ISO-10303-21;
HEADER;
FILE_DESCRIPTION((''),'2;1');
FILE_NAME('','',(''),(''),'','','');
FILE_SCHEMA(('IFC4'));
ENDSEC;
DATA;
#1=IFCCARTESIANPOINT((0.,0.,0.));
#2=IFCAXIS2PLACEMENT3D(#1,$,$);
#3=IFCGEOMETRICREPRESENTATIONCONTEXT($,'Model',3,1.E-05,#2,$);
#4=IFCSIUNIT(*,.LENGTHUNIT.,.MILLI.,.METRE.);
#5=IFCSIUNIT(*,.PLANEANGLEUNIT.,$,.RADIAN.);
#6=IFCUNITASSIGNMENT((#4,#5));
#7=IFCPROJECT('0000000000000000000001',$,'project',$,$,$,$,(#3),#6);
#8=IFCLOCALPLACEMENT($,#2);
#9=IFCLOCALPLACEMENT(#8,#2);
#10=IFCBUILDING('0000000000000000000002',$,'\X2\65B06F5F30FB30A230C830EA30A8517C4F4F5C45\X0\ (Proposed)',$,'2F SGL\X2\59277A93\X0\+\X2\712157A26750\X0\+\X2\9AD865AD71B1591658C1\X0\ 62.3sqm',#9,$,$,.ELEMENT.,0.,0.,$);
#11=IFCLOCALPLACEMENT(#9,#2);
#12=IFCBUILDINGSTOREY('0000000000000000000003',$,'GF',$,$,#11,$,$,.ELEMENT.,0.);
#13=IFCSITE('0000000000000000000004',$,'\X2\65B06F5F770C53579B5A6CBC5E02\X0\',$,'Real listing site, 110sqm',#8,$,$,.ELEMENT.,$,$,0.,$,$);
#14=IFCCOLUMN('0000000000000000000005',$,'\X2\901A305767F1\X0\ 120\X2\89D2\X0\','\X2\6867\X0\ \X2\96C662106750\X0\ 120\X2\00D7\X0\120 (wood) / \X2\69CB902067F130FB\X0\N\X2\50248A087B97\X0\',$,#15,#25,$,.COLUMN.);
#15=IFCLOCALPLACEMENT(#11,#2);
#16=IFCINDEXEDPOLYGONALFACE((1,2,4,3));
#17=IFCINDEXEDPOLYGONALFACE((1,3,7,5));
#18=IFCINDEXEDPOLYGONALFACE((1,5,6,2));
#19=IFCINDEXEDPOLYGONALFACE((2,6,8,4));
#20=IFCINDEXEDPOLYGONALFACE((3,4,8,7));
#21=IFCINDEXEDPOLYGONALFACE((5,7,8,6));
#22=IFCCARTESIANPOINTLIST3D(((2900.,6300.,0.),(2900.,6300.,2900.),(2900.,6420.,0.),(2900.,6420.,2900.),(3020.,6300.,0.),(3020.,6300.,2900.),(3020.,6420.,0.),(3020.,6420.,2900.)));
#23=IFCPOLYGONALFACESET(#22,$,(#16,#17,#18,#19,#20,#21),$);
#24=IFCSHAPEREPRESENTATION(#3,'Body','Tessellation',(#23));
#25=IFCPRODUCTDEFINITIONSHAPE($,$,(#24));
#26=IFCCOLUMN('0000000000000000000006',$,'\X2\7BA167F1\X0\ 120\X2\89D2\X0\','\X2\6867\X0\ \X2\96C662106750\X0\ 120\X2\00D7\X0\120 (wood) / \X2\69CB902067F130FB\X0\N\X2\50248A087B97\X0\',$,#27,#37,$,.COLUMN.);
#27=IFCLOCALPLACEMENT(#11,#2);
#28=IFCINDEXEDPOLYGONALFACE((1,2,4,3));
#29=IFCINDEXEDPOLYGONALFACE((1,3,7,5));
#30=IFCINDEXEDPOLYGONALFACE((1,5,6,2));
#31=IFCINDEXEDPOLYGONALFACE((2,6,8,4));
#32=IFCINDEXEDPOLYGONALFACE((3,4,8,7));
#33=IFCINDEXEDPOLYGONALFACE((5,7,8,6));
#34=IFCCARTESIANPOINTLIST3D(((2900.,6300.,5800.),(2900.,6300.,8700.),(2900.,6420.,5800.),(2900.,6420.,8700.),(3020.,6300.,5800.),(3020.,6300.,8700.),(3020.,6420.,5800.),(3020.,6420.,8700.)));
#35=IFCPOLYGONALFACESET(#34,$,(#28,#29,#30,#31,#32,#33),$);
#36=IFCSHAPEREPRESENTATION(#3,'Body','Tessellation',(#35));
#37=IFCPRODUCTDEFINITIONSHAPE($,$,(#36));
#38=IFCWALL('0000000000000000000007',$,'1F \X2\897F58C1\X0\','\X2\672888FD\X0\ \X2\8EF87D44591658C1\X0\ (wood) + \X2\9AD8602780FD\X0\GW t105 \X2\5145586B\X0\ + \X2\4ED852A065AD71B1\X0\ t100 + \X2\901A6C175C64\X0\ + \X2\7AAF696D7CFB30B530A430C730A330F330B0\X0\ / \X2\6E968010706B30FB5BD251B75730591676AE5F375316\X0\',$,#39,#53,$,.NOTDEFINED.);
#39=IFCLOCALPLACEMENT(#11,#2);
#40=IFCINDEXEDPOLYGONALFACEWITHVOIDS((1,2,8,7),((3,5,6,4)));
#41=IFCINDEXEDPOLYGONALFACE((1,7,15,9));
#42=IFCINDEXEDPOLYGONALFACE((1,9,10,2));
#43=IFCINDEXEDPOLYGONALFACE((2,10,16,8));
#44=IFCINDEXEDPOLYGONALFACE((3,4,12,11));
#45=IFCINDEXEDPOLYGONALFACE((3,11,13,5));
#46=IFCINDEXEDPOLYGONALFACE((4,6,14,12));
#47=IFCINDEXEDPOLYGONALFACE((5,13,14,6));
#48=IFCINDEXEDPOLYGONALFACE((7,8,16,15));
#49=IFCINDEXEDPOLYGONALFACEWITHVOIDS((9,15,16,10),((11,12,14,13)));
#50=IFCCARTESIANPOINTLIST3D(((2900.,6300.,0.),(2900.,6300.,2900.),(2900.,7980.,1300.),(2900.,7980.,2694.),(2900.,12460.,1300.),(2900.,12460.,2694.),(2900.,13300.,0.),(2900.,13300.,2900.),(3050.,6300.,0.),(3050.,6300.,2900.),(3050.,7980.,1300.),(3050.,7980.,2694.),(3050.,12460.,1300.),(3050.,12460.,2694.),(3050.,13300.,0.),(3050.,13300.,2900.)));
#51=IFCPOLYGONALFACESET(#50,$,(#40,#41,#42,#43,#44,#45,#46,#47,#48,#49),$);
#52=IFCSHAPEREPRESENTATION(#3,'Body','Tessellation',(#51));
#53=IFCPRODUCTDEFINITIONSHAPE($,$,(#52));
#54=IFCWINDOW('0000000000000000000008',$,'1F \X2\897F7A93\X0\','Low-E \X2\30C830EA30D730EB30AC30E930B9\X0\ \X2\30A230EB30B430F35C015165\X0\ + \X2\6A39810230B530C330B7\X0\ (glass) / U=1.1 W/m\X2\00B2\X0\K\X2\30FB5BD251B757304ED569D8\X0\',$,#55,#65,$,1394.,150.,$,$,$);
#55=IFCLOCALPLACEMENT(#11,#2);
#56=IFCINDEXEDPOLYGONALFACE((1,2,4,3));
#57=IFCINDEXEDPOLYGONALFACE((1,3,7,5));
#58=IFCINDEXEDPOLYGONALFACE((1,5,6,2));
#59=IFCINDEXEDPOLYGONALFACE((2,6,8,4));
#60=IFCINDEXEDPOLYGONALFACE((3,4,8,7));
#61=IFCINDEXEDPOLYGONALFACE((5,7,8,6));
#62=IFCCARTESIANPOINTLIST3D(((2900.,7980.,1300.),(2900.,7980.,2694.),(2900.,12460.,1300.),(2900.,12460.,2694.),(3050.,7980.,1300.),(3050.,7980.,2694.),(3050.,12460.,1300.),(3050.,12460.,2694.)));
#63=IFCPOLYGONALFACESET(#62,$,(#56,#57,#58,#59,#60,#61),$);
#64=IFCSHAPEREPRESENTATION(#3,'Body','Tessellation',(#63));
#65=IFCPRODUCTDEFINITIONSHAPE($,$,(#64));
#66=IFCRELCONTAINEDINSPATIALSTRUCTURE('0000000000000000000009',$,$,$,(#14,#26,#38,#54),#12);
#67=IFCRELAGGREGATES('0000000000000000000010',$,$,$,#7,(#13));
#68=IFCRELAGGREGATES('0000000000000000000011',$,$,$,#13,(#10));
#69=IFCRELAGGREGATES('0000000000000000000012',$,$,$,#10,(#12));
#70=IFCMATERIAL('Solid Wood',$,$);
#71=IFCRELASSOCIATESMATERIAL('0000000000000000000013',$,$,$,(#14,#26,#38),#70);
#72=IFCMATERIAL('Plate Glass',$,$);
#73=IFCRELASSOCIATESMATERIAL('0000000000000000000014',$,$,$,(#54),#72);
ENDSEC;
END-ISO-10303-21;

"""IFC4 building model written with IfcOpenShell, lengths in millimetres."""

from ifc_helpers import new_model, si_unit, frame, frame_2d, origin, place, context, project, spatial, rectangle, extrude, material, element, fill, save


model = new_model("IFC4")

# Units and contexts
model_context = context("Model", 3, precision=1e-05, world=origin())
ifc_project = project(units=[si_unit("LENGTHUNIT", "METRE", prefix="MILLI"), si_unit("PLANEANGLEUNIT", "RADIAN")], contexts=[model_context])

# Site, building, storey
site_placement = place(None, origin())
site = spatial("IfcSite", under=ifc_project, at=site_placement, Name="新潟県南魚沼市", ObjectType="Real listing site, 110sqm", CompositionType="ELEMENT", RefElevation=0.0)
building_placement = place(site_placement, origin())
building = spatial("IfcBuilding", under=site, at=building_placement, Name="新潟・アトリエ兼住居 (Proposed)", ObjectType="2F SGL大窓+無垢材+高断熱外壁 62.3sqm", CompositionType="ELEMENT", ElevationOfRefHeight=0.0, ElevationOfTerrain=0.0)
storey_placement = place(building_placement, origin())
storey = spatial("IfcBuildingStorey", under=building, at=storey_placement, Name="GF", CompositionType="ELEMENT", Elevation=0.0)

# Columns
ifc_material_1 = material(Name="Solid Wood")
column_1_placement = place(storey_placement, frame((1450.0, 3150.0, 0.0)))
element("IfcColumn", 1, at=column_1_placement, inside=storey, material=ifc_material_1, Name="通し柱 120角", Description="桧 集成材 120×120 (wood) / 構造柱・N値計算", PredefinedType="COLUMN", context=model_context, shape_type="SweptSolid", body=[
    extrude(rectangle(XDim=120.0, YDim=120.0, at=frame_2d((60.0, 60.0))), frame((1450.0, 3150.0, 0.0)), (0.0, 0.0, 1.0), 2900.0),
])
column_2_placement = place(storey_placement, frame((1450.0, 3150.0, 2900.0)))
element("IfcColumn", 2, at=column_2_placement, inside=storey, material=ifc_material_1, Name="管柱 120角", Description="桧 集成材 120×120 (wood) / 構造柱・N値計算", PredefinedType="COLUMN", context=model_context, shape_type="SweptSolid", body=[
    extrude(rectangle(XDim=120.0, YDim=120.0, at=frame_2d((60.0, 60.0))), frame((1450.0, 3150.0, 2900.0)), (0.0, 0.0, 1.0), 2900.0),
])

# Shared definitions
ifc_material_2 = material(Name="Plate Glass")

# Wall, opening, window
wall_1_placement = place(storey_placement, frame((1450.0, 3150.0, 0.0)))
wall_1 = element("IfcWall", 3, at=wall_1_placement, inside=storey, material=ifc_material_1, Name="1F 西壁", Description="木製 軸組外壁 (wood) + 高性能GW t105 充填 + 付加断熱 t100 + 通気層 + 窯業系サイディング / 準耐火・寒冷地外皮強化", PredefinedType="NOTDEFINED", context=model_context, shape_type="SweptSolid", body=[
    extrude(rectangle(XDim=150.0, YDim=7000.0, at=frame_2d((75.0, 3500.0))), frame((1450.0, 3150.0, 0.0)), (0.0, 0.0, 1.0), 2900.0),
])
opening_1_placement = place(storey_placement, frame((1450.0, 3990.0, 650.0)))
opening_1 = element("IfcOpeningElement", 4, at=opening_1_placement, cuts=wall_1, PredefinedType="NOTDEFINED", context=model_context, shape_type="SweptSolid", body=[
    extrude(rectangle(XDim=150.0, YDim=4480.0, at=frame_2d((75.0, 2240.0))), frame((1450.0, 3990.0, 650.0)), (0.0, 0.0, 1.0), 1394.0),
])
window_1_placement = place(storey_placement, frame((1450.0, 3990.0, 650.0)))
window_1 = element("IfcWindow", 5, at=window_1_placement, inside=storey, material=ifc_material_2, Name="1F 西窓", Description="Low-E トリプルガラス アルゴン封入 + 樹脂サッシ (glass) / U=1.1 W/m²K・寒冷地仕様", OverallHeight=1394.0, OverallWidth=150.0, context=model_context, shape_type="SweptSolid", body=[
    extrude(rectangle(XDim=150.0, YDim=4480.0, at=frame_2d((75.0, 2240.0))), frame((1450.0, 3990.0, 650.0)), (0.0, 0.0, 1.0), 1394.0),
])
fill(opening_1, window_1)

save(model, "model.ifc")
